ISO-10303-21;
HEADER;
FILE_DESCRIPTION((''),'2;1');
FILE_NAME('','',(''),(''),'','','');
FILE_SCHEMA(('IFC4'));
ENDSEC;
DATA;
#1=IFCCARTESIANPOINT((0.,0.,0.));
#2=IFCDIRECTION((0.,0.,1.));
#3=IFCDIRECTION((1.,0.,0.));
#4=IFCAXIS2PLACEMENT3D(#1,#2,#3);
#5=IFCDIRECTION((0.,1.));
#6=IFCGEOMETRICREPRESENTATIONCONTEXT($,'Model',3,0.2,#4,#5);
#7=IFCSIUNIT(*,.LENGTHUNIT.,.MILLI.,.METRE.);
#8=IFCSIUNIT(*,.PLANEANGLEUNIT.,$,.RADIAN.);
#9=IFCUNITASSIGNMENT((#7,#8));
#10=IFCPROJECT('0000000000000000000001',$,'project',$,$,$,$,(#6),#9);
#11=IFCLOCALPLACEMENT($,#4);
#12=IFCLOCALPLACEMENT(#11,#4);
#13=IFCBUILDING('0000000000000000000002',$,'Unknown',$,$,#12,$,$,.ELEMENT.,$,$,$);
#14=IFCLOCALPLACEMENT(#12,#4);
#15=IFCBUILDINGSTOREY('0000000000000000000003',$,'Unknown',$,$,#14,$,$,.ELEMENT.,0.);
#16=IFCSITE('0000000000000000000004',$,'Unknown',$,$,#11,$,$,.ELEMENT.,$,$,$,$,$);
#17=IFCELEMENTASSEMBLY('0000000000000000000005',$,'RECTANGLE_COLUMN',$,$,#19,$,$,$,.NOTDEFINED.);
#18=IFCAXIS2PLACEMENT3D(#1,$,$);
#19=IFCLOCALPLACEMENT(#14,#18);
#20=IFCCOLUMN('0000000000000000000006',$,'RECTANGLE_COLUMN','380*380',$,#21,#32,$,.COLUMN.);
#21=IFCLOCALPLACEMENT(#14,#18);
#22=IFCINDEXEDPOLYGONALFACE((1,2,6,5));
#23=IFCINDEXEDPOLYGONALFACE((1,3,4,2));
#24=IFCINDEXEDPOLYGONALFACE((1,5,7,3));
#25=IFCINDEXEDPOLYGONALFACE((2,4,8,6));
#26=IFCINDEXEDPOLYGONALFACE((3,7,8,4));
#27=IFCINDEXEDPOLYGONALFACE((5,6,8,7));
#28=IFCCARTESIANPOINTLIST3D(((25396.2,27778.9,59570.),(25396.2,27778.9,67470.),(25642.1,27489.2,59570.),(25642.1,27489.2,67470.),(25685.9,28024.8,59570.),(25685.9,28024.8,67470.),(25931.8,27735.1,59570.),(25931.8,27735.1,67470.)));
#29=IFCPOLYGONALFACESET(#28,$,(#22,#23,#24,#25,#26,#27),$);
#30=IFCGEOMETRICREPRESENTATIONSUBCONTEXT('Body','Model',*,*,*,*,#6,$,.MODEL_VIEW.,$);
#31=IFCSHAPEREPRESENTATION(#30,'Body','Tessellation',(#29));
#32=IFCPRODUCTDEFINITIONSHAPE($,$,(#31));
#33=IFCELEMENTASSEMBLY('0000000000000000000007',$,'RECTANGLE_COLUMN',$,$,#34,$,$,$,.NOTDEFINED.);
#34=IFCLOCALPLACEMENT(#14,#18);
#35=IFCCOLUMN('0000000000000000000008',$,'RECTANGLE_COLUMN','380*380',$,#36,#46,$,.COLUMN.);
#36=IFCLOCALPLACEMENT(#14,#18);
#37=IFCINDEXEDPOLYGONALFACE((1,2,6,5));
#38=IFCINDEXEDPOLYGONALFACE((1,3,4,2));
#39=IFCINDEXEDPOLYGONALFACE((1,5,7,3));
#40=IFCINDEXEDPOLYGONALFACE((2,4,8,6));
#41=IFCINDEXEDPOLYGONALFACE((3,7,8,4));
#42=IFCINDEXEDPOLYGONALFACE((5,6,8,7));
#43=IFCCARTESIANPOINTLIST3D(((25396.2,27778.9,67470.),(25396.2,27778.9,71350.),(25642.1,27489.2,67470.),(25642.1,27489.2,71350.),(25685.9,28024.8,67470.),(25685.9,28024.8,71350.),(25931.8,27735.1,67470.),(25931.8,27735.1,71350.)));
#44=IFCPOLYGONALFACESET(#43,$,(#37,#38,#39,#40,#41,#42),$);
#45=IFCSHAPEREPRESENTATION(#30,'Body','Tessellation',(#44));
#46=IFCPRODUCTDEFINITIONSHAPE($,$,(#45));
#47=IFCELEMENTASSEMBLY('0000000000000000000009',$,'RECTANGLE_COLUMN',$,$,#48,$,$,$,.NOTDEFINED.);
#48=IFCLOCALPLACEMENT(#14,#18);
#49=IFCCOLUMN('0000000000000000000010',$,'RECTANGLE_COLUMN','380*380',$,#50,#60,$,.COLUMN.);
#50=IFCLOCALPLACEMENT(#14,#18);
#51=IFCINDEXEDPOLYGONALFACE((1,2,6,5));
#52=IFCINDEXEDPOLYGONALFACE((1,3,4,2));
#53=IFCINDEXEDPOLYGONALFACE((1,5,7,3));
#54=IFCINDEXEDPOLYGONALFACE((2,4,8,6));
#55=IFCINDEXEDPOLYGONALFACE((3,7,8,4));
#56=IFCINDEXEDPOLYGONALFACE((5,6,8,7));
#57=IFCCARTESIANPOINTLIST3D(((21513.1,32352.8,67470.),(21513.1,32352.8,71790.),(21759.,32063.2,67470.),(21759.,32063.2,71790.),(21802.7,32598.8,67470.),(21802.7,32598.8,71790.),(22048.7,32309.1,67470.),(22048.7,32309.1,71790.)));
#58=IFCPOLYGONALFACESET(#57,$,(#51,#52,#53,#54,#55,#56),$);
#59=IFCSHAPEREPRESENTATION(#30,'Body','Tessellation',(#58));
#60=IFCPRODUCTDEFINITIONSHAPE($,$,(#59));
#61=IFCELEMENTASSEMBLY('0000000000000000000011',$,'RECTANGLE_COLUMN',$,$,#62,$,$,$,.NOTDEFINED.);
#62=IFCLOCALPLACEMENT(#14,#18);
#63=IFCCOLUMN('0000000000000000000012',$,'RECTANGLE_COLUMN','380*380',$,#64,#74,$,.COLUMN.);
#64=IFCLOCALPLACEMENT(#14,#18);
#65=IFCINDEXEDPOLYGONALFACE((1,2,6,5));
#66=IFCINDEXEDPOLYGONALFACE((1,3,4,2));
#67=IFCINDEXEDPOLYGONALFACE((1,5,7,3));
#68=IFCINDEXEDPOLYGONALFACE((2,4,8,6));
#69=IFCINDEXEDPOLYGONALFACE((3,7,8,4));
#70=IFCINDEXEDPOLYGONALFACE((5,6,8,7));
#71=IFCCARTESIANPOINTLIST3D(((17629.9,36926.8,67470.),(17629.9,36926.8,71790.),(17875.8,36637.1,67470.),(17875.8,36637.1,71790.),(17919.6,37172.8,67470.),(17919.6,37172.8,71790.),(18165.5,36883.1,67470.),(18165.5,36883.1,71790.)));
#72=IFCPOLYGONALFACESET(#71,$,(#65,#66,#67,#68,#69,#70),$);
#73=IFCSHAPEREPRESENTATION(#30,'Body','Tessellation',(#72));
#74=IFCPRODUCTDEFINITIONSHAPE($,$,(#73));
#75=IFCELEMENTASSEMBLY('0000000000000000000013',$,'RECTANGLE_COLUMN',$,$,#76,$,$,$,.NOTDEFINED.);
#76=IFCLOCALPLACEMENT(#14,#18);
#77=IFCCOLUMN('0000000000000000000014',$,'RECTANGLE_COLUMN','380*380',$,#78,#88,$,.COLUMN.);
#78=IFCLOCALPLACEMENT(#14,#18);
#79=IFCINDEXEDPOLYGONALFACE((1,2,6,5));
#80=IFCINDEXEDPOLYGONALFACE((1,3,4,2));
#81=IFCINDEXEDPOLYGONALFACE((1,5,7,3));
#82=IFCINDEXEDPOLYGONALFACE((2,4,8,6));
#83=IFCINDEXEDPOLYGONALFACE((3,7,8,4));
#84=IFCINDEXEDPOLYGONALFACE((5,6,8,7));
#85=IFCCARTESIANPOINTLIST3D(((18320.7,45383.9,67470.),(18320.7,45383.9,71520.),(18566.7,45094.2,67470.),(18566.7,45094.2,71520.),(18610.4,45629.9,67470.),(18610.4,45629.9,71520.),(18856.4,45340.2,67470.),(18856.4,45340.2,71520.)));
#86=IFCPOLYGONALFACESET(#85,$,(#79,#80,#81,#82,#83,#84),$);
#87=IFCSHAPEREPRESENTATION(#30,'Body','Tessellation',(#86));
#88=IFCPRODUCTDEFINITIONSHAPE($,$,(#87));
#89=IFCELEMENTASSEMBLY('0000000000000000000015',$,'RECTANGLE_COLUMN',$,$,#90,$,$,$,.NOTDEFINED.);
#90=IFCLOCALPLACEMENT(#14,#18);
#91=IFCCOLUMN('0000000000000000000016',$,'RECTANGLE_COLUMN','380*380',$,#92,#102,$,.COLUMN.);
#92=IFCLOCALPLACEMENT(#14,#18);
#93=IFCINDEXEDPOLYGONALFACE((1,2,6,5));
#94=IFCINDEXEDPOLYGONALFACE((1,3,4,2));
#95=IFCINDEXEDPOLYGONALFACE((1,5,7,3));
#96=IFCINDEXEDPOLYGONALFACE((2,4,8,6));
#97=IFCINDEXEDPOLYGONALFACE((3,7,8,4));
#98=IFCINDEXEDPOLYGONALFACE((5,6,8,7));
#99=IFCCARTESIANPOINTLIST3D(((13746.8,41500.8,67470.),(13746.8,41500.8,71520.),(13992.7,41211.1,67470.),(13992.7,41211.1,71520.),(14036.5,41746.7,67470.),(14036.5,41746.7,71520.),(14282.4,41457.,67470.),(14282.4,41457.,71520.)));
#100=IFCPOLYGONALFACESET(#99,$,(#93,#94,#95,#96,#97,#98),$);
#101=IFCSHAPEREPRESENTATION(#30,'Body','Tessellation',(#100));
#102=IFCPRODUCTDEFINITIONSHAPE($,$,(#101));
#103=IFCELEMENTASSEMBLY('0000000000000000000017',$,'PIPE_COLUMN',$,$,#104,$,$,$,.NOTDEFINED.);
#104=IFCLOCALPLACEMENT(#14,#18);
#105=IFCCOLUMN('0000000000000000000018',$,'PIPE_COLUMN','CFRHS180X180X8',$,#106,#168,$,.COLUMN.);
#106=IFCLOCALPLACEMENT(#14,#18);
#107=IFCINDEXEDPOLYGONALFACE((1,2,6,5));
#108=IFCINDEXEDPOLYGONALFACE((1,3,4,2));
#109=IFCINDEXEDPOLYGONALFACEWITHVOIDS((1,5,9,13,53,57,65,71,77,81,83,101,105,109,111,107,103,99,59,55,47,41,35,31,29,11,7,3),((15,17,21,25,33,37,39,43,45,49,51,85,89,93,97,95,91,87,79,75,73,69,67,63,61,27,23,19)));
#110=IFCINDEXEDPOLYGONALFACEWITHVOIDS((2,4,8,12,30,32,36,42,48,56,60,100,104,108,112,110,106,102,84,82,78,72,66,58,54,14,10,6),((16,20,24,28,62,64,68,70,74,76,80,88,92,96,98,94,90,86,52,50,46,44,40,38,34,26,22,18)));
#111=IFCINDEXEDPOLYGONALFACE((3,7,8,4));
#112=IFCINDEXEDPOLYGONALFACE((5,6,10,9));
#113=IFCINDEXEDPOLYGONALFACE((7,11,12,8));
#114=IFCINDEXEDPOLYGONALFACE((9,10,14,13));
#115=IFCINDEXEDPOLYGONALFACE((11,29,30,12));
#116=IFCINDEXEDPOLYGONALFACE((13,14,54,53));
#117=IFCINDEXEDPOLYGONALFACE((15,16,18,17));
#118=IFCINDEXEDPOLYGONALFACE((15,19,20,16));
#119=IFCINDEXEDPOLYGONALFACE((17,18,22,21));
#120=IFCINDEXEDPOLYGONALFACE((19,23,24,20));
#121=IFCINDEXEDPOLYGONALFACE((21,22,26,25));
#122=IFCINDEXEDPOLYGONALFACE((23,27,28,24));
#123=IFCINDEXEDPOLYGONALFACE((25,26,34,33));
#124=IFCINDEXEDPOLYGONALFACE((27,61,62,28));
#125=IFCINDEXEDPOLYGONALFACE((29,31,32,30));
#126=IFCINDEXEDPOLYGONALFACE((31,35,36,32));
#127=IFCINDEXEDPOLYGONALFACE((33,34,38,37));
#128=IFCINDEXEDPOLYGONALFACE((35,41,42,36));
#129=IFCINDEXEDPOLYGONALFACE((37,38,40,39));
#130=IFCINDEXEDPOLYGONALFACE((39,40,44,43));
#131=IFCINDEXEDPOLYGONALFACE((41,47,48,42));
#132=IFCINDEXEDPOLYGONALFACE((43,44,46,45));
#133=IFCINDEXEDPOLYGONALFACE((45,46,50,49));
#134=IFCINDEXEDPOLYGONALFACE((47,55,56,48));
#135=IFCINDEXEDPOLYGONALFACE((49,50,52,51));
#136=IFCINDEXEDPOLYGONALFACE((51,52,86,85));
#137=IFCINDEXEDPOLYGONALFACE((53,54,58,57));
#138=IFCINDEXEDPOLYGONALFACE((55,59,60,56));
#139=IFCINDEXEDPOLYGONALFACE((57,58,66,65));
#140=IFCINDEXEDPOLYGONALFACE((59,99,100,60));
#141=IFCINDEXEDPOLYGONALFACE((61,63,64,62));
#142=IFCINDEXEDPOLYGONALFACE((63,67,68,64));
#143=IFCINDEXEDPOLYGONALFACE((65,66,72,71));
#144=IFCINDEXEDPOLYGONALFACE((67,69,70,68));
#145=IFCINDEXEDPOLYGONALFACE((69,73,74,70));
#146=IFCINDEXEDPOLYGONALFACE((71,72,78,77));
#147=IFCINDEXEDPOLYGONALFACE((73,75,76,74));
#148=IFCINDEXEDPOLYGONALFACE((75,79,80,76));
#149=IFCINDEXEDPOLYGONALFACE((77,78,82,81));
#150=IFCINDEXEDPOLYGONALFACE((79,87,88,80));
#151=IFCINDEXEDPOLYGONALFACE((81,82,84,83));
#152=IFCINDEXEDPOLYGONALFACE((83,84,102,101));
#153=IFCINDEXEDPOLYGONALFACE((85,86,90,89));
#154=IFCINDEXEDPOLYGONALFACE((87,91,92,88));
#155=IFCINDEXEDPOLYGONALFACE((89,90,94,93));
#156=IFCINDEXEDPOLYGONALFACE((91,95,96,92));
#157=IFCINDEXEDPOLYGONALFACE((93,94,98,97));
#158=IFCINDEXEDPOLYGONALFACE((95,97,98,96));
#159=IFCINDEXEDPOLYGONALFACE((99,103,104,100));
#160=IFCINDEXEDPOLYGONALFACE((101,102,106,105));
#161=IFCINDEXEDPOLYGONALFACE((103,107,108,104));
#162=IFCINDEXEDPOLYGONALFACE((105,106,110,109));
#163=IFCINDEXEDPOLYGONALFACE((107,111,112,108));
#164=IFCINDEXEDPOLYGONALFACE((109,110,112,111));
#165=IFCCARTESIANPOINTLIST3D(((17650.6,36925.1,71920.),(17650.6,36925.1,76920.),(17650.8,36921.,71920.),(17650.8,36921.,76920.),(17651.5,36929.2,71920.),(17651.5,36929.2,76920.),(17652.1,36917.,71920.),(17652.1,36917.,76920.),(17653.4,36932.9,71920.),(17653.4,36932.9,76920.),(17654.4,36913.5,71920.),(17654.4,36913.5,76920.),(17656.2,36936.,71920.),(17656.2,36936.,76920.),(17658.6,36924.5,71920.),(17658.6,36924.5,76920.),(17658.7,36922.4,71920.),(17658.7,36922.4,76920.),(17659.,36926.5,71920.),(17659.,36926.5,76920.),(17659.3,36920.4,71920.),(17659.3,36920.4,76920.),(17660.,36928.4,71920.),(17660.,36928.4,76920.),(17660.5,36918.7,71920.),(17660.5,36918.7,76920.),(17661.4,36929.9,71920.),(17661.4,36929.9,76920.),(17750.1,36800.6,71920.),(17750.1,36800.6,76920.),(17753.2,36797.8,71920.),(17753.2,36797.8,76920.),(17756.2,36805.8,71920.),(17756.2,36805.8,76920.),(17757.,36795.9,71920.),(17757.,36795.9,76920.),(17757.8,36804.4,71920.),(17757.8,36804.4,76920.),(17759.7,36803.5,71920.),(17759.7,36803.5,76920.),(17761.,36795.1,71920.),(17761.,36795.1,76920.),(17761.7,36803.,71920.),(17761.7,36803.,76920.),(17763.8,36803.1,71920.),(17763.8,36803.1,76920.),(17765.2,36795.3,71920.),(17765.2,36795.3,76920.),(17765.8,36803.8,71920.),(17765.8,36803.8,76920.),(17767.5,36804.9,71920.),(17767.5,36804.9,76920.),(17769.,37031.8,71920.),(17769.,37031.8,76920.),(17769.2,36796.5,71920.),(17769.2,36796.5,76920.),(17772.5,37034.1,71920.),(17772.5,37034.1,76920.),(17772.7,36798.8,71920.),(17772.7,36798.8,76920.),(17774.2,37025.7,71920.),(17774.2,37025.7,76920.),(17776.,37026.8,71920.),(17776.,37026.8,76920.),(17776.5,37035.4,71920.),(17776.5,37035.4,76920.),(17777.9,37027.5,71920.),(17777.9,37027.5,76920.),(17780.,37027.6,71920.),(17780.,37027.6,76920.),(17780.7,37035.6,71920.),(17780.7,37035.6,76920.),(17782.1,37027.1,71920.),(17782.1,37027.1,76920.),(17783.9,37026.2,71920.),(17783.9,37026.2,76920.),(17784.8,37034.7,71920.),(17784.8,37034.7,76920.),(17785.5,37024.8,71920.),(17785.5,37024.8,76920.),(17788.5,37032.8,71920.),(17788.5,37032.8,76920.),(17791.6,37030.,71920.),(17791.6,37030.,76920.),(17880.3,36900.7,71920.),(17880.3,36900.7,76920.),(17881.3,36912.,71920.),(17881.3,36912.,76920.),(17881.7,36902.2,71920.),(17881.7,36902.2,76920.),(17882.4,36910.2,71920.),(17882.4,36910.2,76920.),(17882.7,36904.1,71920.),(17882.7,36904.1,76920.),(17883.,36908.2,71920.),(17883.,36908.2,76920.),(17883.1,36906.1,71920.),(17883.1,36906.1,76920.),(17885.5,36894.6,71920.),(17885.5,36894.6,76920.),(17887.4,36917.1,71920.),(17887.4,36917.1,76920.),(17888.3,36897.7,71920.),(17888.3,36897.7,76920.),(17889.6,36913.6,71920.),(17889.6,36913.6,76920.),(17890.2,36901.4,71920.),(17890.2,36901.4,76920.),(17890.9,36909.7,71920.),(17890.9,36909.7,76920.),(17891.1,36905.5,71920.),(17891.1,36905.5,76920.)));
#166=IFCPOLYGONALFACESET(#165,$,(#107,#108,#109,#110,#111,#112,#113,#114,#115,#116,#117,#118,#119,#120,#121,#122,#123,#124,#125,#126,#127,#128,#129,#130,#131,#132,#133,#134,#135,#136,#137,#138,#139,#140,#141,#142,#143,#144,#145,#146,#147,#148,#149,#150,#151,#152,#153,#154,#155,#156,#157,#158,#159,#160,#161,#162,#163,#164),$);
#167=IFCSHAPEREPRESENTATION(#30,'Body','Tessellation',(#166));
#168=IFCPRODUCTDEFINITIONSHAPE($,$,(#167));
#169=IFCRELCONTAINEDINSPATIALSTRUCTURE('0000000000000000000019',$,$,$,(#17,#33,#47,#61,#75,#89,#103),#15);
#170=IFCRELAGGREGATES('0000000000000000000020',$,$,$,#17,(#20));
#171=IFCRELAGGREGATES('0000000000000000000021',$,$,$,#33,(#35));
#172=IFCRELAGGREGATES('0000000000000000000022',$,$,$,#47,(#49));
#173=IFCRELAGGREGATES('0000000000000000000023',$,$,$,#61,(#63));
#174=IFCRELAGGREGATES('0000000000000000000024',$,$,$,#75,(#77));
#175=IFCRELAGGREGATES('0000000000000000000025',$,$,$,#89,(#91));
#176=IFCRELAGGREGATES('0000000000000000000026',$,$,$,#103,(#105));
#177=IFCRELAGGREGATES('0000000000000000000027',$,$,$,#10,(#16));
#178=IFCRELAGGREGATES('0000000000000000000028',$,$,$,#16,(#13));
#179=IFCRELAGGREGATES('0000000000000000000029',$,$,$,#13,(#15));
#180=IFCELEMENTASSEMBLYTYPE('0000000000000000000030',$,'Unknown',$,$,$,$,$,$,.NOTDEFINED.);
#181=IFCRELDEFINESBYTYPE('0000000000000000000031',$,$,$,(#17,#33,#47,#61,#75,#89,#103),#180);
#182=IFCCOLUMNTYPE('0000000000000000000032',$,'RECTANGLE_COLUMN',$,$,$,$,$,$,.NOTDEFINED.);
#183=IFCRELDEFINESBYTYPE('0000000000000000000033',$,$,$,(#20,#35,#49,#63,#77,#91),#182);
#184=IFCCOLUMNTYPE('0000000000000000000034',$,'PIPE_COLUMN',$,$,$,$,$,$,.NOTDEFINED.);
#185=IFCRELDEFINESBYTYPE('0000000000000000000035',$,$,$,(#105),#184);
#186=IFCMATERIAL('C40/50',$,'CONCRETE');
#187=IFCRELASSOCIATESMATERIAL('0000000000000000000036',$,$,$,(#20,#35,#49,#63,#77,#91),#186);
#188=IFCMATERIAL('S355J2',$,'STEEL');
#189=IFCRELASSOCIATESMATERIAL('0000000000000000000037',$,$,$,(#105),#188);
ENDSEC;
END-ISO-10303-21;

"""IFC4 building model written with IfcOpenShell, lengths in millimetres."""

from ifc_helpers import new_model, si_unit, direction, frame, origin_with_axes, origin_2d_with_axis, place, context, subcontext, project, spatial, rectangle, hollow_rectangle, extrude, material, material_profile, profile_set, profile_usage, type_object, element, aggregate, save


model = new_model("IFC4")

# Units and contexts
model_context = context("Model", 3, precision=0.2, world=origin_with_axes(), true_north=direction((0.0, 1.0)))
body_context = subcontext(model_context, "Body", "Model", "MODEL_VIEW")
ifc_project = project(units=[si_unit("LENGTHUNIT", "METRE", prefix="MILLI"), si_unit("PLANEANGLEUNIT", "RADIAN")], contexts=[model_context])

# Site, building, storey
site_placement = place(None, origin_with_axes())
site = spatial("IfcSite", under=ifc_project, at=site_placement, Name="Unknown", CompositionType="ELEMENT")
building_placement = place(site_placement, origin_with_axes())
building = spatial("IfcBuilding", under=site, at=building_placement, Name="Unknown", CompositionType="ELEMENT")
storey_placement = place(building_placement, origin_with_axes())
storey = spatial("IfcBuildingStorey", under=building, at=storey_placement, Name="Unknown", CompositionType="ELEMENT", Elevation=0.0)

# Element assemblies, columns
element_assembly_type = type_object("IfcElementAssemblyType", Name="Unknown", PredefinedType="NOTDEFINED")
assembly_1_placement = place(storey_placement, frame((25664.0, 27757.0, 59570.0), z_axis=(-0.762329, -0.64719, 0.0), x_axis=(0.0, 0.0, 1.0)))
assembly_1 = element("IfcElementAssembly", 1, at=assembly_1_placement, inside=storey, type_object=element_assembly_type, Name="RECTANGLE_COLUMN", PredefinedType="NOTDEFINED")
ifc_material_1 = material(Name="C40/50", Category="CONCRETE")
ifc_material_profile_1 = material_profile(ifc_material_1, rectangle(XDim=380.0, YDim=380.0, at=origin_2d_with_axis()), Name="380*380")
ifc_profile_set_1 = profile_set([ifc_material_profile_1])
ifc_profile_usage_1 = profile_usage(ifc_profile_set_1, cardinal=5)
column_type_1 = type_object("IfcColumnType", Name="RECTANGLE_COLUMN")
column_1_placement = place(assembly_1_placement, origin_with_axes())
column_1 = element("IfcColumn", 2, at=column_1_placement, type_object=column_type_1, material=ifc_profile_usage_1, Name="RECTANGLE_COLUMN", Description="380*380", PredefinedType="COLUMN", context=body_context, shape_type="SolidModel", body=[
    extrude(rectangle(XDim=380.0, YDim=380.0, at=origin_2d_with_axis()), frame((0.0, 0.0, 0.0), z_axis=(-1.0, 0.0, 0.0), x_axis=(0.0, 0.0, 1.0)), (0.0, 0.0, -1.0), 7900.0),
])
aggregate(assembly_1, [column_1])
assembly_2_placement = place(storey_placement, frame((25664.0, 27757.0, 67470.0), z_axis=(-0.762329, -0.64719, 0.0), x_axis=(0.0, 0.0, 1.0)))
assembly_2 = element("IfcElementAssembly", 3, at=assembly_2_placement, inside=storey, type_object=element_assembly_type, Name="RECTANGLE_COLUMN", PredefinedType="NOTDEFINED")
column_2_placement = place(assembly_2_placement, origin_with_axes())
column_2 = element("IfcColumn", 4, at=column_2_placement, type_object=column_type_1, material=ifc_profile_usage_1, Name="RECTANGLE_COLUMN", Description="380*380", PredefinedType="COLUMN", context=body_context, shape_type="SolidModel", body=[
    extrude(rectangle(XDim=380.0, YDim=380.0, at=origin_2d_with_axis()), frame((0.0, 0.0, 0.0), z_axis=(-1.0, 0.0, 0.0), x_axis=(0.0, 0.0, 1.0)), (0.0, 0.0, -1.0), 3880.0),
])
aggregate(assembly_2, [column_2])
assembly_3_placement = place(storey_placement, frame((21780.9, 32331.0, 67470.0), z_axis=(-0.762329, -0.64719, 0.0), x_axis=(0.0, 0.0, 1.0)))
assembly_3 = element("IfcElementAssembly", 5, at=assembly_3_placement, inside=storey, type_object=element_assembly_type, Name="RECTANGLE_COLUMN", PredefinedType="NOTDEFINED")
column_3_placement = place(assembly_3_placement, origin_with_axes())
column_3 = element("IfcColumn", 6, at=column_3_placement, type_object=column_type_1, material=ifc_profile_usage_1, Name="RECTANGLE_COLUMN", Description="380*380", PredefinedType="COLUMN", context=body_context, shape_type="SolidModel", body=[
    extrude(rectangle(XDim=380.0, YDim=380.0, at=origin_2d_with_axis()), frame((0.0, 0.0, 0.0), z_axis=(-1.0, 0.0, 0.0), x_axis=(0.0, 0.0, 1.0)), (0.0, 0.0, -1.0), 4320.0),
])
aggregate(assembly_3, [column_3])
assembly_4_placement = place(storey_placement, frame((17897.7, 36904.9, 67470.0), z_axis=(-0.762329, -0.64719, 0.0), x_axis=(0.0, 0.0, 1.0)))
assembly_4 = element("IfcElementAssembly", 7, at=assembly_4_placement, inside=storey, type_object=element_assembly_type, Name="RECTANGLE_COLUMN", PredefinedType="NOTDEFINED")
column_4_placement = place(assembly_4_placement, origin_with_axes())
column_4 = element("IfcColumn", 8, at=column_4_placement, type_object=column_type_1, material=ifc_profile_usage_1, Name="RECTANGLE_COLUMN", Description="380*380", PredefinedType="COLUMN", context=body_context, shape_type="SolidModel", body=[
    extrude(rectangle(XDim=380.0, YDim=380.0, at=origin_2d_with_axis()), frame((0.0, 0.0, 0.0), z_axis=(-1.0, 0.0, 0.0), x_axis=(0.0, 0.0, 1.0)), (0.0, 0.0, -1.0), 4320.0),
])
aggregate(assembly_4, [column_4])
assembly_5_placement = place(storey_placement, frame((18588.6, 45362.1, 67470.0), z_axis=(-0.762329, -0.64719, 0.0), x_axis=(0.0, 0.0, 1.0)))
assembly_5 = element("IfcElementAssembly", 9, at=assembly_5_placement, inside=storey, type_object=element_assembly_type, Name="RECTANGLE_COLUMN", PredefinedType="NOTDEFINED")
column_5_placement = place(assembly_5_placement, origin_with_axes())
column_5 = element("IfcColumn", 10, at=column_5_placement, type_object=column_type_1, material=ifc_profile_usage_1, Name="RECTANGLE_COLUMN", Description="380*380", PredefinedType="COLUMN", context=body_context, shape_type="SolidModel", body=[
    extrude(rectangle(XDim=380.0, YDim=380.0, at=origin_2d_with_axis()), frame((0.0, 0.0, 0.0), z_axis=(-1.0, 0.0, 0.0), x_axis=(0.0, 0.0, 1.0)), (0.0, 0.0, -1.0), 4050.0),
])
aggregate(assembly_5, [column_5])
assembly_6_placement = place(storey_placement, frame((14014.6, 41478.9, 67470.0), z_axis=(-0.762329, -0.64719, 0.0), x_axis=(0.0, 0.0, 1.0)))
assembly_6 = element("IfcElementAssembly", 11, at=assembly_6_placement, inside=storey, type_object=element_assembly_type, Name="RECTANGLE_COLUMN", PredefinedType="NOTDEFINED")
column_6_placement = place(assembly_6_placement, origin_with_axes())
column_6 = element("IfcColumn", 12, at=column_6_placement, type_object=column_type_1, material=ifc_profile_usage_1, Name="RECTANGLE_COLUMN", Description="380*380", PredefinedType="COLUMN", context=body_context, shape_type="SolidModel", body=[
    extrude(rectangle(XDim=380.0, YDim=380.0, at=origin_2d_with_axis()), frame((0.0, 0.0, 0.0), z_axis=(-1.0, 0.0, 0.0), x_axis=(0.0, 0.0, 1.0)), (0.0, 0.0, -1.0), 4050.0),
])
aggregate(assembly_6, [column_6])
assembly_7_placement = place(storey_placement, frame((17770.9, 36915.3, 71920.0), z_axis=(-0.762329, -0.64719, 0.0), x_axis=(0.0, 0.0, 1.0)))
assembly_7 = element("IfcElementAssembly", 13, at=assembly_7_placement, inside=storey, type_object=element_assembly_type, Name="PIPE_COLUMN", PredefinedType="NOTDEFINED")
ifc_material_2 = material(Name="S355J2", Category="STEEL")
ifc_material_profile_2 = material_profile(ifc_material_2, hollow_rectangle(XDim=180.0, YDim=180.0, WallThickness=8.0, InnerFilletRadius=8.0, OuterFilletRadius=16.0, at=origin_2d_with_axis()), Name="CFRHS180X180X8")
ifc_profile_set_2 = profile_set([ifc_material_profile_2])
ifc_profile_usage_2 = profile_usage(ifc_profile_set_2, cardinal=3)
column_type_2 = type_object("IfcColumnType", Name="PIPE_COLUMN")
column_7_placement = place(assembly_7_placement, origin_with_axes())
column_7 = element("IfcColumn", 14, at=column_7_placement, type_object=column_type_2, material=ifc_profile_usage_2, Name="PIPE_COLUMN", Description="CFRHS180X180X8", PredefinedType="COLUMN", context=body_context, shape_type="SolidModel", body=[
    extrude(hollow_rectangle(XDim=180.0, YDim=180.0, WallThickness=8.0, InnerFilletRadius=8.0, OuterFilletRadius=16.0, at=origin_2d_with_axis()), frame((0.0, 0.0, 0.0), z_axis=(-1.0, 0.0, 0.0), x_axis=(0.0, 0.0, 1.0)), (0.0, 0.0, -1.0), 5000.0),
])
aggregate(assembly_7, [column_7])

save(model, "model.ifc")
